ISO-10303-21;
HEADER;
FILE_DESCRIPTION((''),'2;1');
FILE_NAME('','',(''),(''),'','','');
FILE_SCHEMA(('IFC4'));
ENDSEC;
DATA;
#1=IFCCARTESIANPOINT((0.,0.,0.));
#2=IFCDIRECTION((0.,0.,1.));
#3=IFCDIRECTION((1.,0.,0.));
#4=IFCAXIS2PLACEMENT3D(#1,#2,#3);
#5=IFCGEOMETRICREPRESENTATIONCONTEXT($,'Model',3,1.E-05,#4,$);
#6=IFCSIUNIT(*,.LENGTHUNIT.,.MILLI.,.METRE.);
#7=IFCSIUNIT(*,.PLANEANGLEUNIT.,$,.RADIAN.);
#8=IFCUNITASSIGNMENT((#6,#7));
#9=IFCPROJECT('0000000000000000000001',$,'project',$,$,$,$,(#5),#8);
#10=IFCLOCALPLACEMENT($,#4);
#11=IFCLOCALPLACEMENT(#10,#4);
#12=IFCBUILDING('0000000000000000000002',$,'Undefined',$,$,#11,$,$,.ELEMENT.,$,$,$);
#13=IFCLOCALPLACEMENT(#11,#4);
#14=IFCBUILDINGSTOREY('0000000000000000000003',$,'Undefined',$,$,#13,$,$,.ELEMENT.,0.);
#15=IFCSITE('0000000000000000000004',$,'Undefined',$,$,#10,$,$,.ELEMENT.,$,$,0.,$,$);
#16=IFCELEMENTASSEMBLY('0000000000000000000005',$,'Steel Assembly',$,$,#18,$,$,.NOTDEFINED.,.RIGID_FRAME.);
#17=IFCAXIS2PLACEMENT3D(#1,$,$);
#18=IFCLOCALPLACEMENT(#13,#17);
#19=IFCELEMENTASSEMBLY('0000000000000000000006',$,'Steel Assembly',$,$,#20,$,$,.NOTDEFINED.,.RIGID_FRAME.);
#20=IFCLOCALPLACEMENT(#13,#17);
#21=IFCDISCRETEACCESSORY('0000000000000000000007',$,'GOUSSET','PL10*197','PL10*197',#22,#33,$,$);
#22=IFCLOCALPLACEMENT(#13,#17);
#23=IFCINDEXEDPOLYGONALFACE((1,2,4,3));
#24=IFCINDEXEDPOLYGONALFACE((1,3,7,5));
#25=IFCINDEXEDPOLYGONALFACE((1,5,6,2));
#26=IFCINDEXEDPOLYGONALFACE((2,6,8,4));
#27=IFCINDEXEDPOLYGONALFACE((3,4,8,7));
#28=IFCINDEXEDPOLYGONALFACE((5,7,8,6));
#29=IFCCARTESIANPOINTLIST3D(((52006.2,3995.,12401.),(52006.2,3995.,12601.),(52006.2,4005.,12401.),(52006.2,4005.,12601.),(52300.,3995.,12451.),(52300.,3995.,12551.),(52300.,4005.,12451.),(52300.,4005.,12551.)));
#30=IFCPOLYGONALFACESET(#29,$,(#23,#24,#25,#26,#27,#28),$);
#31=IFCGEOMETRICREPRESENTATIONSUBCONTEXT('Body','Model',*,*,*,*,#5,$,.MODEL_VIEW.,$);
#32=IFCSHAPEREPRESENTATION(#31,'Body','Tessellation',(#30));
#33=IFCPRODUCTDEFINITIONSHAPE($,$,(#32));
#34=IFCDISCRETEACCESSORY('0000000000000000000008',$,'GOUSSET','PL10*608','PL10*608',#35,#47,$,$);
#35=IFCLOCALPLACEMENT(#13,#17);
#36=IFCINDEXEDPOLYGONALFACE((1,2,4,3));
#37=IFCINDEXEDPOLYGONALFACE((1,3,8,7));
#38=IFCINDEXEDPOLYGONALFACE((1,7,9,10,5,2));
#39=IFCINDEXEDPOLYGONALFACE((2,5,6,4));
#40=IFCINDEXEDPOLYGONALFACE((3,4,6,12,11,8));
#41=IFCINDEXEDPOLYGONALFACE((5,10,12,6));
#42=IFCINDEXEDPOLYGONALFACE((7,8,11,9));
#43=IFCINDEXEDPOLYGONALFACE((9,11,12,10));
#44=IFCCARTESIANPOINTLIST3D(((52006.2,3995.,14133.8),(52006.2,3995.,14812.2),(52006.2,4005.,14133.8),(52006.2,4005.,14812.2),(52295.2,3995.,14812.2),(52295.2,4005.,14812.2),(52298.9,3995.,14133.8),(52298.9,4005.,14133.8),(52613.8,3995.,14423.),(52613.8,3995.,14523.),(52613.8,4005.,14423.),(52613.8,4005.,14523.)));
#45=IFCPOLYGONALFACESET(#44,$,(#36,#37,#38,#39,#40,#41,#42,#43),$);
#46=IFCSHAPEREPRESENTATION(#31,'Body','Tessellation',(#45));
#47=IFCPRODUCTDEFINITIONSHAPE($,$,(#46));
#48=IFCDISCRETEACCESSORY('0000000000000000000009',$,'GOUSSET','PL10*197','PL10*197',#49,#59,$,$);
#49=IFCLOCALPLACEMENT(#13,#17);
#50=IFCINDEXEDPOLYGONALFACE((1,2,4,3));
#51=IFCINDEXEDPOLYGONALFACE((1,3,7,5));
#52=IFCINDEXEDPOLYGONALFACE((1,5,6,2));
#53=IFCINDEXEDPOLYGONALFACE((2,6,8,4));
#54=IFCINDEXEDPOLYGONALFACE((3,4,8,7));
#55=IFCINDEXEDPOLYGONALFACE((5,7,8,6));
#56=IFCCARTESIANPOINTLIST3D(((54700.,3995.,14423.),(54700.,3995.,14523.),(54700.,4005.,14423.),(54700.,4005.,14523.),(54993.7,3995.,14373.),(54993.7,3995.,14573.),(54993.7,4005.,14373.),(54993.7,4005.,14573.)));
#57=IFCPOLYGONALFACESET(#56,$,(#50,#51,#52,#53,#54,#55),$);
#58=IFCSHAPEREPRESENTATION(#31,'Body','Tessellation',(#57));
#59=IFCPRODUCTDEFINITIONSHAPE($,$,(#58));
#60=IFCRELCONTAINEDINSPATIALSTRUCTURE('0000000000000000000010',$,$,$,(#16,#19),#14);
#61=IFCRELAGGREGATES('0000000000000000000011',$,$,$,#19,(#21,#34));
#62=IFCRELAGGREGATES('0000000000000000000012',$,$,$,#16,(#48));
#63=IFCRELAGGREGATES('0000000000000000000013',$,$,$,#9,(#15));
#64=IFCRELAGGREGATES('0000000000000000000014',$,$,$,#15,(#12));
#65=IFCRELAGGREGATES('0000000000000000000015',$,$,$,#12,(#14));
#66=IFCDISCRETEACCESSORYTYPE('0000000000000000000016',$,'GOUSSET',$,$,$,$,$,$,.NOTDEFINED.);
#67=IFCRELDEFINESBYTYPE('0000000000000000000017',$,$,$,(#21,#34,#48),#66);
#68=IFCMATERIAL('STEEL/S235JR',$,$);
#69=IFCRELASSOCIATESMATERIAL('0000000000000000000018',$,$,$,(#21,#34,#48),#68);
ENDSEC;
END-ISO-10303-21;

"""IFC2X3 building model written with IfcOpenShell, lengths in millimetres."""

from ifc_helpers import new_model, si_unit, frame, origin_with_axes, place, context, subcontext, project, spatial, polyline, outline, extrude, material, type_object, element, aggregate, save


model = new_model("IFC2X3")

# Units and contexts
model_context = context("Model", 3, precision=1e-05, world=origin_with_axes())
body_context = subcontext(model_context, "Body", "Model", "MODEL_VIEW")
ifc_project = project(units=[si_unit("LENGTHUNIT", "METRE", prefix="MILLI"), si_unit("PLANEANGLEUNIT", "RADIAN")], contexts=[model_context])

# Site, building, storey
site_placement = place(None, origin_with_axes())
site = spatial("IfcSite", under=ifc_project, at=site_placement, Name="Undefined", CompositionType="ELEMENT", RefElevation=0.0)
building_placement = place(site_placement, origin_with_axes())
building = spatial("IfcBuilding", under=site, at=building_placement, Name="Undefined", CompositionType="ELEMENT")
storey_placement = place(building_placement, origin_with_axes())
storey = spatial("IfcBuildingStorey", under=building, at=storey_placement, Name="Undefined", CompositionType="ELEMENT", Elevation=0.0)

# Shared definitions
ifc_material_1 = material(Name="STEEL/S235JR")

# Element assembly
assembly_1_placement = place(storey_placement, origin_with_axes())
assembly_1 = element("IfcElementAssembly", 1, at=assembly_1_placement, inside=storey, Name="Steel Assembly", AssemblyPlace="NOTDEFINED", PredefinedType="RIGID_FRAME")

# Element assembly, discrete accessories
assembly_2_placement = place(storey_placement, origin_with_axes())
assembly_2 = element("IfcElementAssembly", 2, at=assembly_2_placement, inside=storey, Name="Steel Assembly", AssemblyPlace="NOTDEFINED", PredefinedType="RIGID_FRAME")
discrete_accessory_type_1 = type_object("IfcDiscreteAccessoryType", Name="GOUSSET")
discrete_accessory_1_placement = place(assembly_2_placement, frame((52006.2, 4000.0, 12601.0), z_axis=(0.0, -1.0, 0.0), x_axis=(0.0, 0.0, -1.0)))
discrete_accessory_1 = element("IfcDiscreteAccessory", 3, at=discrete_accessory_1_placement, type_object=discrete_accessory_type_1, material=ifc_material_1, Name="GOUSSET", Description="PL10*197", ObjectType="PL10*197", context=body_context, shape_type="SweptSolid", body=[
    extrude(outline(polyline([(0.0, 0.0), (200.0, 0.0), (150.0, 293.8), (50.0, 293.8), (0.0, 0.0)])), frame((0.0, 0.0, -5.0), z_axis=(0.0, 0.0, 1.0), x_axis=(1.0, 0.0, 0.0)), (0.0, 0.0, 1.0), 10.0),
])
discrete_accessory_2_placement = place(assembly_2_placement, frame((52006.2, 4000.0, 14812.2), z_axis=(0.0, 1.0, 0.0), x_axis=(1.0, 0.0, 0.0)))
discrete_accessory_2 = element("IfcDiscreteAccessory", 4, at=discrete_accessory_2_placement, type_object=discrete_accessory_type_1, material=ifc_material_1, Name="GOUSSET", Description="PL10*608", ObjectType="PL10*608", context=body_context, shape_type="SweptSolid", body=[
    extrude(outline(polyline([(0.0, 0.0), (288.9, 0.0), (607.5, 289.2), (607.5, 389.2), (292.6, 678.5), (0.0, 678.5), (0.0, 0.0)])), frame((0.0, 0.0, -5.0), z_axis=(0.0, 0.0, 1.0), x_axis=(1.0, 0.0, 0.0)), (0.0, 0.0, 1.0), 10.0),
])
aggregate(assembly_2, [discrete_accessory_1, discrete_accessory_2])

# Discrete accessory
discrete_accessory_3_placement = place(assembly_1_placement, frame((54993.7, 4000.0, 14573.0), z_axis=(0.0, 1.0, 0.0), x_axis=(0.0, 0.0, -1.0)))
discrete_accessory_3 = element("IfcDiscreteAccessory", 5, at=discrete_accessory_3_placement, type_object=discrete_accessory_type_1, material=ifc_material_1, Name="GOUSSET", Description="PL10*197", ObjectType="PL10*197", context=body_context, shape_type="SweptSolid", body=[
    extrude(outline(polyline([(0.0, 0.0), (200.0, 0.0), (150.0, 293.8), (50.0, 293.8), (0.0, 0.0)])), frame((0.0, 0.0, -5.0), z_axis=(0.0, 0.0, 1.0), x_axis=(1.0, 0.0, 0.0)), (0.0, 0.0, 1.0), 10.0),
])
aggregate(assembly_1, [discrete_accessory_3])

save(model, "model.ifc")
